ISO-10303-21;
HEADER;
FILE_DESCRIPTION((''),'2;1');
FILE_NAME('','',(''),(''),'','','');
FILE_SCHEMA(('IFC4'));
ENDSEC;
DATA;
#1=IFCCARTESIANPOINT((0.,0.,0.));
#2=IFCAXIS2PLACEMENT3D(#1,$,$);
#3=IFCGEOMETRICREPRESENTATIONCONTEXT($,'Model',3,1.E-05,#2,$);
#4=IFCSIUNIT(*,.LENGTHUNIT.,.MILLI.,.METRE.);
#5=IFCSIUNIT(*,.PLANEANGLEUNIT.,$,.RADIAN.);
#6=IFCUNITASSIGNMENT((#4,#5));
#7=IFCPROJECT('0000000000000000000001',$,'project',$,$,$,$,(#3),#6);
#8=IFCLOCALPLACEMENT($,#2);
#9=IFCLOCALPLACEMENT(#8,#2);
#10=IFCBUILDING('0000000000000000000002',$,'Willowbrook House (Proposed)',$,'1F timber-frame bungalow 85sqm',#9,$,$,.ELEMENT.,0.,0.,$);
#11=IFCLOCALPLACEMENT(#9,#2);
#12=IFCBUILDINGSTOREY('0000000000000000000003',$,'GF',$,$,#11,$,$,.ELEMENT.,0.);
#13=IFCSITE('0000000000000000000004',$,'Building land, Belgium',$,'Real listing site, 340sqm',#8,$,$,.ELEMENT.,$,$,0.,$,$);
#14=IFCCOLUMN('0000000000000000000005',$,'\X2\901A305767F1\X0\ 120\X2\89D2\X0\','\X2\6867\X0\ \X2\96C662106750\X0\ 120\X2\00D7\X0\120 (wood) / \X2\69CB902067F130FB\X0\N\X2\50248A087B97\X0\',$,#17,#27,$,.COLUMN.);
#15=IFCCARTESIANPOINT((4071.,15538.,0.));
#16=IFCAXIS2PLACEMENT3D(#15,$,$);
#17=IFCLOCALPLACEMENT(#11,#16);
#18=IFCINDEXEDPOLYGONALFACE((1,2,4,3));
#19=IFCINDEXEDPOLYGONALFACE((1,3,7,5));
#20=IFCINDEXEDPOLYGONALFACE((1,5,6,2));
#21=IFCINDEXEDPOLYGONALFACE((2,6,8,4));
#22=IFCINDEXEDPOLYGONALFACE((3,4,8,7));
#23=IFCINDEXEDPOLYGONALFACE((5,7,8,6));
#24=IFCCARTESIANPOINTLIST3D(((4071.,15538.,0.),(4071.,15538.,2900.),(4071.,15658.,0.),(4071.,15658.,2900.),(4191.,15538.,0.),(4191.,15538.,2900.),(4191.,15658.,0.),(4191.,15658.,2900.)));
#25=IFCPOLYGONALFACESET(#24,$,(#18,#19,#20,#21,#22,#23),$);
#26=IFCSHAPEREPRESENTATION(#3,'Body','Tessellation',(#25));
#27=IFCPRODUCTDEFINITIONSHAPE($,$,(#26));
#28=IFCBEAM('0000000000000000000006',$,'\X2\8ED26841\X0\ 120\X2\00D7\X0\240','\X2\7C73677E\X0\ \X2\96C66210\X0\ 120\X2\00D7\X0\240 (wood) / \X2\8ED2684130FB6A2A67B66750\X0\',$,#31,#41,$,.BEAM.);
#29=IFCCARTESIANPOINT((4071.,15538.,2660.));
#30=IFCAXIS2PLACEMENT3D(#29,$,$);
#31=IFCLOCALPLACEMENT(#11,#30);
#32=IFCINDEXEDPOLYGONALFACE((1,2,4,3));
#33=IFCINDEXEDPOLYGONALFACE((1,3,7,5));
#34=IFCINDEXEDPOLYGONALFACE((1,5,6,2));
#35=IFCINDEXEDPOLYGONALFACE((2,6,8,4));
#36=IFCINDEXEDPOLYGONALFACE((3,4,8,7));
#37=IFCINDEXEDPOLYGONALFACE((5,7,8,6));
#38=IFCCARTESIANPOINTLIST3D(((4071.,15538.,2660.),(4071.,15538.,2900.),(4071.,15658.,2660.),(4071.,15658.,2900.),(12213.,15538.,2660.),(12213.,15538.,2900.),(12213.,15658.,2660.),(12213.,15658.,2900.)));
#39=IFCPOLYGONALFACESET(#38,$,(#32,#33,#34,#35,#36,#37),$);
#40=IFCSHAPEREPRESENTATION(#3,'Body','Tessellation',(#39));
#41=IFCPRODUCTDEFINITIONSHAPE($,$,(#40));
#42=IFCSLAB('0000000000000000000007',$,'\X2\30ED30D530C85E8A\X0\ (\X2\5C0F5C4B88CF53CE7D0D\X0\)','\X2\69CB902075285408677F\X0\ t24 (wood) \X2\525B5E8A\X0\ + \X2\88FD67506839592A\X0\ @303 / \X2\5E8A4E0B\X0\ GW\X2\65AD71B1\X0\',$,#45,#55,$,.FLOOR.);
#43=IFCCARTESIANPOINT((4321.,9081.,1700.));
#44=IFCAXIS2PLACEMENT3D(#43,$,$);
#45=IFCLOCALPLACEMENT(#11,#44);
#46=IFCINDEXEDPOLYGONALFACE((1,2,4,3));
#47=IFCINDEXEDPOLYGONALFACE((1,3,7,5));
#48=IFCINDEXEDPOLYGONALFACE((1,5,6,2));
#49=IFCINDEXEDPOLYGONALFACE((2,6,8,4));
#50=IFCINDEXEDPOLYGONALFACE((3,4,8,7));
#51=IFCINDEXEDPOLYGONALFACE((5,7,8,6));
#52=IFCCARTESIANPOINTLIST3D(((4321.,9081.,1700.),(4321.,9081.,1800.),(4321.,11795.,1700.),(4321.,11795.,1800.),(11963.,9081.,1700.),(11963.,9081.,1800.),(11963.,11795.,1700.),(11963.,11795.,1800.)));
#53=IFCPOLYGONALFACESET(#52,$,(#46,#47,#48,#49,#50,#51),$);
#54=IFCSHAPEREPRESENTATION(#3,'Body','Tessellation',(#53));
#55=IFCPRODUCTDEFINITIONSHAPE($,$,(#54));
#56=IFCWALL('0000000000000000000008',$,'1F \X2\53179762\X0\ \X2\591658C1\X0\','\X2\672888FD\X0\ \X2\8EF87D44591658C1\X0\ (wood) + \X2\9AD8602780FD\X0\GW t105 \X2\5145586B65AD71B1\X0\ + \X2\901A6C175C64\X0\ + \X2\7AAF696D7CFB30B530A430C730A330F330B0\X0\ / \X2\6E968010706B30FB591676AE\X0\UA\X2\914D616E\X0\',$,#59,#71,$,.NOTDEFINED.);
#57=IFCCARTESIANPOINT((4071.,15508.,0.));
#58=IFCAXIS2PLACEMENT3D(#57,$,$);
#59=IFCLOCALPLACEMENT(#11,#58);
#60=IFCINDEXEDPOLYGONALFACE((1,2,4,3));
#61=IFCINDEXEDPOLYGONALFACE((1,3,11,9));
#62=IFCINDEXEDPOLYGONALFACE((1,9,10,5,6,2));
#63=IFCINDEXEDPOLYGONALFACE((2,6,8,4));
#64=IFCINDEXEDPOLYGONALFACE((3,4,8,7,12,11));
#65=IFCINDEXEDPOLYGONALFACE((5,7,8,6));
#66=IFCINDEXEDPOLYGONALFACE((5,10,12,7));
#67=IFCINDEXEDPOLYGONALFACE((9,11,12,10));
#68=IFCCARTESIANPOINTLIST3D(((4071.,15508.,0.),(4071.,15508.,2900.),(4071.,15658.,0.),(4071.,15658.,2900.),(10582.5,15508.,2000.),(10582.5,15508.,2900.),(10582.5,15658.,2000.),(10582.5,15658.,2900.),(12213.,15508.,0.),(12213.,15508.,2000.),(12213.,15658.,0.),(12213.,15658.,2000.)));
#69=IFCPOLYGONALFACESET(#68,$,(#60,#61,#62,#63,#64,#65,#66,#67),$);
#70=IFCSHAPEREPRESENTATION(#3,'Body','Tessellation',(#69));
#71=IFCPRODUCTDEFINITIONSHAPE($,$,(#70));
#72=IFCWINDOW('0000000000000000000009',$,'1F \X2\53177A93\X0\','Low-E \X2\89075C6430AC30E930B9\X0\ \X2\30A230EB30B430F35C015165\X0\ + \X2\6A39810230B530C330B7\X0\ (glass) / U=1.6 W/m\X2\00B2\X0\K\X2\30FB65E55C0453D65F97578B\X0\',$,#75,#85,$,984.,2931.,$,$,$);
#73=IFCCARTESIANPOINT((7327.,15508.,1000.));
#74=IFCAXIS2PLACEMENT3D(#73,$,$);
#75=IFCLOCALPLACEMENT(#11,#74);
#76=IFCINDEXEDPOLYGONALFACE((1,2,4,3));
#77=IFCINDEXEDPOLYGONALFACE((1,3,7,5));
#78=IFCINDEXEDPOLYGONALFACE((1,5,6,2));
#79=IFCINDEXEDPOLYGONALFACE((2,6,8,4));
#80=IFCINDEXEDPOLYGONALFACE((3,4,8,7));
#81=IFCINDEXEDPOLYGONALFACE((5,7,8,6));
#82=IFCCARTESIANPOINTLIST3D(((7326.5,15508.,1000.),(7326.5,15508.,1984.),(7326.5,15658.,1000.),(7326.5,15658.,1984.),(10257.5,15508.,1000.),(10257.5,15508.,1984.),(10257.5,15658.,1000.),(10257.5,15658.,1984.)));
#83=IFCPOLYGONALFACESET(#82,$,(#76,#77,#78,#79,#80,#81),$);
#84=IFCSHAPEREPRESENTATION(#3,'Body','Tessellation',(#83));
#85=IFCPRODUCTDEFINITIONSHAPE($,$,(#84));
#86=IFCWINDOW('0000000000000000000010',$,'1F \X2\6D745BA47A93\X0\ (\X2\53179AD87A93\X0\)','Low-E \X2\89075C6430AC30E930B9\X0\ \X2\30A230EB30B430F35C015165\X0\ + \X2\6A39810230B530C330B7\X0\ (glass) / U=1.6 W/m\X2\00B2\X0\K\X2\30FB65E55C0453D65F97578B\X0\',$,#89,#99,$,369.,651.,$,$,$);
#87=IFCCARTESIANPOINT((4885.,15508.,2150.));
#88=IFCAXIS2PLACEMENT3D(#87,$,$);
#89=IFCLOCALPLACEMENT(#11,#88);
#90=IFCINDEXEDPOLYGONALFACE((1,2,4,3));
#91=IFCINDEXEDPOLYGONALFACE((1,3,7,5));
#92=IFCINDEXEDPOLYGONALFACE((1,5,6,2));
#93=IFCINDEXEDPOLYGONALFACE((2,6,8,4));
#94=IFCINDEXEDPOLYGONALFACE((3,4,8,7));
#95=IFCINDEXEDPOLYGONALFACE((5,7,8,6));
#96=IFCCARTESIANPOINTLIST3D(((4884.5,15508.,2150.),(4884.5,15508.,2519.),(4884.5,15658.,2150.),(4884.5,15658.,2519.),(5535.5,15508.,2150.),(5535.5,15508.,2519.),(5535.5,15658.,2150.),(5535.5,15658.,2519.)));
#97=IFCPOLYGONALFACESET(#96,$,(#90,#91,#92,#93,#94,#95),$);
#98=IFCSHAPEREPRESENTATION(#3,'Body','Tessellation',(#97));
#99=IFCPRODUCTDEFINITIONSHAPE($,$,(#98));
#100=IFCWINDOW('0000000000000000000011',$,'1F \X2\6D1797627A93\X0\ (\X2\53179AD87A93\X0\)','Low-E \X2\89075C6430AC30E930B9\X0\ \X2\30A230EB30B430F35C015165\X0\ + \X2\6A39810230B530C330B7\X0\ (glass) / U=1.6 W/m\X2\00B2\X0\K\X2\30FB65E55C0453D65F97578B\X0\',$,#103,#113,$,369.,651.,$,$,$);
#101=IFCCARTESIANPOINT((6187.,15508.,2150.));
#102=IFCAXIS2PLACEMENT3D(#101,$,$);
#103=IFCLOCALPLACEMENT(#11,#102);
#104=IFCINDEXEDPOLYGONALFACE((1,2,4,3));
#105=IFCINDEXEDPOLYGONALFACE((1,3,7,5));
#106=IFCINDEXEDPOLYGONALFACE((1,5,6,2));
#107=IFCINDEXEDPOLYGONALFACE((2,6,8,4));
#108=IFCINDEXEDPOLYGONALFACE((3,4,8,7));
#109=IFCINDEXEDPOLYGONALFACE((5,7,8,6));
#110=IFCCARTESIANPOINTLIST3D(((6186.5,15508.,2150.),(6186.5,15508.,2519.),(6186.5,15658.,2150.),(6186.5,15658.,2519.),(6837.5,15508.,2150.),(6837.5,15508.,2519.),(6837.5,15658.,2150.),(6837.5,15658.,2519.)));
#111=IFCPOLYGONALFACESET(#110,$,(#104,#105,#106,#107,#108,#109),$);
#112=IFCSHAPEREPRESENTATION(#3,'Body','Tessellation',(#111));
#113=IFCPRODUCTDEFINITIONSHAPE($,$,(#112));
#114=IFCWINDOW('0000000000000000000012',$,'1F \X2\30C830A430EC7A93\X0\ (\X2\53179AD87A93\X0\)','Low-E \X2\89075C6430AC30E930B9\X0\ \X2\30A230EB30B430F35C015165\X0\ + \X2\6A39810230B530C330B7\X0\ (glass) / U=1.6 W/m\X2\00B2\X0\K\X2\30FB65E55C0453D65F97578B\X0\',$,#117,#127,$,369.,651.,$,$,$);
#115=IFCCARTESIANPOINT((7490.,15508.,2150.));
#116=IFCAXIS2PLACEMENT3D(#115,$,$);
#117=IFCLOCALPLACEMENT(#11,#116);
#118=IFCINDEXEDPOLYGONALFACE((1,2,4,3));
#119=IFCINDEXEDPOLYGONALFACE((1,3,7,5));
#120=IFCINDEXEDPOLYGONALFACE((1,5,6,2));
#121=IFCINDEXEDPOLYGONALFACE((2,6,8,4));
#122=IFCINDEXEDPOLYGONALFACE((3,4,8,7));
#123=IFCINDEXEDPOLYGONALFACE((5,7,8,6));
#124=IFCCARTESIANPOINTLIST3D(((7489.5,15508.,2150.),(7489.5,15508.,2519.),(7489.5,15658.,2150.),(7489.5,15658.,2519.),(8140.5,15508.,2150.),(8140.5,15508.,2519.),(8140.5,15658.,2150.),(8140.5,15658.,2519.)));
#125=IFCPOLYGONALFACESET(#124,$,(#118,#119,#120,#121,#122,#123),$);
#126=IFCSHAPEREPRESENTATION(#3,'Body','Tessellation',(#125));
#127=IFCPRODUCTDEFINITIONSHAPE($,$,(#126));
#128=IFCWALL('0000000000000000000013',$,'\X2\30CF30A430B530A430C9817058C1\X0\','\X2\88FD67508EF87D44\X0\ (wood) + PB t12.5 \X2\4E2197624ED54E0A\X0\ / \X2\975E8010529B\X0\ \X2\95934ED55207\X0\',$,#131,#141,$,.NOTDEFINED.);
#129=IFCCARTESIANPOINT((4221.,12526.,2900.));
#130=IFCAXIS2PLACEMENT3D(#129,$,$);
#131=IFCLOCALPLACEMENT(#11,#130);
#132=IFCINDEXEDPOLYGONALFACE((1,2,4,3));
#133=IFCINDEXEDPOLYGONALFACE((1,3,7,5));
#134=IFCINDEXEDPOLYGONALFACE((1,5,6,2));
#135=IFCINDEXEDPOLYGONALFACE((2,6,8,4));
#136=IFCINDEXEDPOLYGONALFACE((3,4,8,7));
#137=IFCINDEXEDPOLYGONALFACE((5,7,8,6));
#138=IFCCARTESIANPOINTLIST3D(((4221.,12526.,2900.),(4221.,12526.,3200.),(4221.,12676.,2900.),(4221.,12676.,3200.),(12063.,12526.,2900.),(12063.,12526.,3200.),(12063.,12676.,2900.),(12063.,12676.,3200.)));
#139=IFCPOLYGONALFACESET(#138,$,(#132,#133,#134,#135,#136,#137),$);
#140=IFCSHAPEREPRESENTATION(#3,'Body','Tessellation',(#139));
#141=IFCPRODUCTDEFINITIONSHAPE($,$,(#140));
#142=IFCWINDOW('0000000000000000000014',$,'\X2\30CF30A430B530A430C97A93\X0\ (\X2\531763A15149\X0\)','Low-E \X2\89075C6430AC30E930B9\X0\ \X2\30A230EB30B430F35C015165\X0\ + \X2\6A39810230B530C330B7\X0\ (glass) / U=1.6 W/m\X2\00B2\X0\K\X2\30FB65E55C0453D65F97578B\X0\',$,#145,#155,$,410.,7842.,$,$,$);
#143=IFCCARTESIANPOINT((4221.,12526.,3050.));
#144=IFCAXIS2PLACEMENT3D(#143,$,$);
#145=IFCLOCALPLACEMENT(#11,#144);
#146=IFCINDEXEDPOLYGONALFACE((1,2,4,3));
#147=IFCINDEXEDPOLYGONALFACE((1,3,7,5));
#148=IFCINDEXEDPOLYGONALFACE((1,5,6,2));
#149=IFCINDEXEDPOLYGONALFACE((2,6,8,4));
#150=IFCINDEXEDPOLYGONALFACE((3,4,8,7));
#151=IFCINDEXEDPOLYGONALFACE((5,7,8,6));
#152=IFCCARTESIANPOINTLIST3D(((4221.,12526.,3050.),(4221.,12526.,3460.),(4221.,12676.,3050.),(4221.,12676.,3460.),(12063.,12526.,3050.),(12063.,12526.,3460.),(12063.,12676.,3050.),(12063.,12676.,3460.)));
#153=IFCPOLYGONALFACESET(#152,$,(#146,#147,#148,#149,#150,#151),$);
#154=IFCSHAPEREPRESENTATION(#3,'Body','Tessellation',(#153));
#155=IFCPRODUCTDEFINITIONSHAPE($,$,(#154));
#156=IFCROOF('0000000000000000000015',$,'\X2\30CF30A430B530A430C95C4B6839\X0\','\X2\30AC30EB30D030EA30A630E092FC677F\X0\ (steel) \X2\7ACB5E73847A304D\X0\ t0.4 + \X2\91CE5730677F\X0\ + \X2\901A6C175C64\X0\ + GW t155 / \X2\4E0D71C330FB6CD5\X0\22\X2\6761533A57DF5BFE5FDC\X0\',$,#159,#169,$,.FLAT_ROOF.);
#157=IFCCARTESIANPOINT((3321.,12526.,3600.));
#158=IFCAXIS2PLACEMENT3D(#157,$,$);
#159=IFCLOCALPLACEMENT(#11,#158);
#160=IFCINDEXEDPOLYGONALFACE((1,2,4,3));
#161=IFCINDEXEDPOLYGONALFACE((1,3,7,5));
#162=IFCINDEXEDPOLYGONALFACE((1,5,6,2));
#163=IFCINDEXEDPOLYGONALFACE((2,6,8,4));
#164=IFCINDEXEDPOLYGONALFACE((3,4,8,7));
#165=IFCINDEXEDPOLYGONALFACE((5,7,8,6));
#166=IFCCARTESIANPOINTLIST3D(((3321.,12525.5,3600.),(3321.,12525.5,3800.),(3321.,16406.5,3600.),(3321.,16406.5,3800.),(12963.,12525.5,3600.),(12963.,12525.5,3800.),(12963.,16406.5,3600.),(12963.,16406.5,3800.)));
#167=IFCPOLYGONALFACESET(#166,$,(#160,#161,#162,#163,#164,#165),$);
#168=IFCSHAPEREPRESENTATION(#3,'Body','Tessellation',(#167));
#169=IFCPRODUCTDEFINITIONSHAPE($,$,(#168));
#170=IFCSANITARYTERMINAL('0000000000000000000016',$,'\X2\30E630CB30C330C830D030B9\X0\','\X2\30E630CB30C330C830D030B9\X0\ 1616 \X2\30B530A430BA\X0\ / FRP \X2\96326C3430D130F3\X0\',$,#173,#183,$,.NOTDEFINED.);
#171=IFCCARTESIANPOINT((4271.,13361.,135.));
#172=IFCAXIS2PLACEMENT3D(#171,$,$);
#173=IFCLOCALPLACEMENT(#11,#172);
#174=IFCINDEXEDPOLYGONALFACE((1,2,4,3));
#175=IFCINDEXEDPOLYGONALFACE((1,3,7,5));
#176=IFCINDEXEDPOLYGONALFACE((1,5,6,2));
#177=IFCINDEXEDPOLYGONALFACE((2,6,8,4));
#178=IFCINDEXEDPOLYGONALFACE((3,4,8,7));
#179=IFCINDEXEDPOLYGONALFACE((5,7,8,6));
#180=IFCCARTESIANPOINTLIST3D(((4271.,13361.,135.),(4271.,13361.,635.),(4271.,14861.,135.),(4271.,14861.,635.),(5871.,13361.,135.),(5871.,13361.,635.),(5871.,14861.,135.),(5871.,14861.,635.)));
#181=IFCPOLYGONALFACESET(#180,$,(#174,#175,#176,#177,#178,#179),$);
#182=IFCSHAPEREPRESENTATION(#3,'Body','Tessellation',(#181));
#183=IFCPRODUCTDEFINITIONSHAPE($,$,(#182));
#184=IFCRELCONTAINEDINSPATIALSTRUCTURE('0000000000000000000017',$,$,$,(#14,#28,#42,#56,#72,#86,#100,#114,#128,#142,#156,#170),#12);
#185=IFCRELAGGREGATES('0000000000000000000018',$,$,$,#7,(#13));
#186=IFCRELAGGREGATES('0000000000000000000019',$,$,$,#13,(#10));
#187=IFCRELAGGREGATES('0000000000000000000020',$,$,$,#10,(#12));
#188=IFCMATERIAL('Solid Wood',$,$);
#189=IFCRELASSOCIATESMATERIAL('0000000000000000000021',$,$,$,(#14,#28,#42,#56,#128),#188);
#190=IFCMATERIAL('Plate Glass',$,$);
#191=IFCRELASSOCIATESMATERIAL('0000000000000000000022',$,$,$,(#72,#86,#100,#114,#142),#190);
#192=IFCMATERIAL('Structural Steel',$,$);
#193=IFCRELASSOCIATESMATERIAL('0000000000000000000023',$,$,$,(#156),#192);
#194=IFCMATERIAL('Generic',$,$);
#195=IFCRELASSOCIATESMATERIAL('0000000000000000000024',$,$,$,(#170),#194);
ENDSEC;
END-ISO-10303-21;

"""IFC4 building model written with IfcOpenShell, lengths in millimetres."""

from ifc_helpers import new_model, si_unit, frame, frame_2d, origin, place, context, project, spatial, rectangle, extrude, material, element, fill, save


model = new_model("IFC4")

# Units and contexts
model_context = context("Model", 3, precision=1e-05, world=origin())
ifc_project = project(units=[si_unit("LENGTHUNIT", "METRE", prefix="MILLI"), si_unit("PLANEANGLEUNIT", "RADIAN")], contexts=[model_context])

# Site, building, storey
site_placement = place(None, origin())
site = spatial("IfcSite", under=ifc_project, at=site_placement, Name="Building land, Belgium", ObjectType="Real listing site, 340sqm", CompositionType="ELEMENT", RefElevation=0.0)
building_placement = place(site_placement, origin())
building = spatial("IfcBuilding", under=site, at=building_placement, Name="Willowbrook House (Proposed)", ObjectType="1F timber-frame bungalow 85sqm", CompositionType="ELEMENT", ElevationOfRefHeight=0.0, ElevationOfTerrain=0.0)
storey_placement = place(building_placement, origin())
storey = spatial("IfcBuildingStorey", under=building, at=storey_placement, Name="GF", CompositionType="ELEMENT", Elevation=0.0)

# Column
ifc_material_1 = material(Name="Solid Wood")
column_1_placement = place(storey_placement, frame((4071.0, 15538.0, 0.0)))
element("IfcColumn", 1, at=column_1_placement, inside=storey, material=ifc_material_1, Name="通し柱 120角", Description="桧 集成材 120×120 (wood) / 構造柱・N値計算", PredefinedType="COLUMN", context=model_context, shape_type="SweptSolid", body=[
    extrude(rectangle(XDim=120.0, YDim=120.0, at=frame_2d((60.0, 60.0))), frame((4071.0, 15538.0, 0.0)), (0.0, 0.0, 1.0), 2900.0),
])

# Beam
beam_1_placement = place(storey_placement, frame((4071.0, 15538.0, 2660.0)))
element("IfcBeam", 2, at=beam_1_placement, inside=storey, material=ifc_material_1, Name="軒桁 120×240", Description="米松 集成 120×240 (wood) / 軒桁・横架材", PredefinedType="BEAM", context=model_context, shape_type="SweptSolid", body=[
    extrude(rectangle(XDim=8142.0, YDim=120.0, at=frame_2d((4071.0, 60.0))), frame((4071.0, 15538.0, 2660.0)), (0.0, 0.0, 1.0), 240.0),
])

# Slab
slab_placement = place(storey_placement, frame((4321.0, 9081.0, 1700.0)))
element("IfcSlab", 3, at=slab_placement, inside=storey, material=ifc_material_1, Name="ロフト床 (小屋裏収納)", Description="構造用合板 t24 (wood) 剛床 + 製材根太 @303 / 床下 GW断熱", PredefinedType="FLOOR", context=model_context, shape_type="SweptSolid", body=[
    extrude(rectangle(XDim=7642.0, YDim=2714.0, at=frame_2d((3821.0, 1357.0))), frame((4321.0, 9081.0, 1700.0)), (0.0, 0.0, 1.0), 100.0),
])

# Wall, openings, windows
wall_1_placement = place(storey_placement, frame((4071.0, 15508.0, 0.0)))
wall_1 = element("IfcWall", 4, at=wall_1_placement, inside=storey, material=ifc_material_1, Name="1F 北面 外壁", Description="木製 軸組外壁 (wood) + 高性能GW t105 充填断熱 + 通気層 + 窯業系サイディング / 準耐火・外皮UA配慮", PredefinedType="NOTDEFINED", context=model_context, shape_type="SweptSolid", body=[
    extrude(rectangle(XDim=8142.0, YDim=150.0, at=frame_2d((4071.0, 75.0))), frame((4071.0, 15508.0, 0.0)), (0.0, 0.0, 1.0), 2900.0),
])
opening_1_placement = place(storey_placement, frame((7327.0, 15508.0, 1000.0)))
opening_1 = element("IfcOpeningElement", 5, at=opening_1_placement, cuts=wall_1, PredefinedType="NOTDEFINED", context=model_context, shape_type="SweptSolid", body=[
    extrude(rectangle(XDim=2931.0, YDim=150.0, at=frame_2d((1465.0, 75.0))), frame((7327.0, 15508.0, 1000.0)), (0.0, 0.0, 1.0), 984.0),
])
opening_2_placement = place(storey_placement, frame((4885.0, 15508.0, 2150.0)))
opening_2 = element("IfcOpeningElement", 6, at=opening_2_placement, cuts=wall_1, PredefinedType="NOTDEFINED", context=model_context, shape_type="SweptSolid", body=[
    extrude(rectangle(XDim=651.0, YDim=150.0, at=frame_2d((325.0, 75.0))), frame((4885.0, 15508.0, 2150.0)), (0.0, 0.0, 1.0), 369.0),
])
opening_3_placement = place(storey_placement, frame((6187.0, 15508.0, 2150.0)))
opening_3 = element("IfcOpeningElement", 7, at=opening_3_placement, cuts=wall_1, PredefinedType="NOTDEFINED", context=model_context, shape_type="SweptSolid", body=[
    extrude(rectangle(XDim=651.0, YDim=150.0, at=frame_2d((325.0, 75.0))), frame((6187.0, 15508.0, 2150.0)), (0.0, 0.0, 1.0), 369.0),
])
opening_4_placement = place(storey_placement, frame((7490.0, 15508.0, 2150.0)))
opening_4 = element("IfcOpeningElement", 8, at=opening_4_placement, cuts=wall_1, PredefinedType="NOTDEFINED", context=model_context, shape_type="SweptSolid", body=[
    extrude(rectangle(XDim=651.0, YDim=150.0, at=frame_2d((325.0, 75.0))), frame((7490.0, 15508.0, 2150.0)), (0.0, 0.0, 1.0), 369.0),
])
ifc_material_2 = material(Name="Plate Glass")
window_1_placement = place(storey_placement, frame((7327.0, 15508.0, 1000.0)))
window_1 = element("IfcWindow", 9, at=window_1_placement, inside=storey, material=ifc_material_2, Name="1F 北窓", Description="Low-E 複層ガラス アルゴン封入 + 樹脂サッシ (glass) / U=1.6 W/m²K・日射取得型", OverallHeight=984.0, OverallWidth=2931.0, context=model_context, shape_type="SweptSolid", body=[
    extrude(rectangle(XDim=2931.0, YDim=150.0, at=frame_2d((1465.0, 75.0))), frame((7327.0, 15508.0, 1000.0)), (0.0, 0.0, 1.0), 984.0),
])
fill(opening_1, window_1)
window_2_placement = place(storey_placement, frame((4885.0, 15508.0, 2150.0)))
window_2 = element("IfcWindow", 10, at=window_2_placement, inside=storey, material=ifc_material_2, Name="1F 浴室窓 (北高窓)", Description="Low-E 複層ガラス アルゴン封入 + 樹脂サッシ (glass) / U=1.6 W/m²K・日射取得型", OverallHeight=369.0, OverallWidth=651.0, context=model_context, shape_type="SweptSolid", body=[
    extrude(rectangle(XDim=651.0, YDim=150.0, at=frame_2d((325.0, 75.0))), frame((4885.0, 15508.0, 2150.0)), (0.0, 0.0, 1.0), 369.0),
])
fill(opening_2, window_2)
window_3_placement = place(storey_placement, frame((6187.0, 15508.0, 2150.0)))
window_3 = element("IfcWindow", 11, at=window_3_placement, inside=storey, material=ifc_material_2, Name="1F 洗面窓 (北高窓)", Description="Low-E 複層ガラス アルゴン封入 + 樹脂サッシ (glass) / U=1.6 W/m²K・日射取得型", OverallHeight=369.0, OverallWidth=651.0, context=model_context, shape_type="SweptSolid", body=[
    extrude(rectangle(XDim=651.0, YDim=150.0, at=frame_2d((325.0, 75.0))), frame((6187.0, 15508.0, 2150.0)), (0.0, 0.0, 1.0), 369.0),
])
fill(opening_3, window_3)
window_4_placement = place(storey_placement, frame((7490.0, 15508.0, 2150.0)))
window_4 = element("IfcWindow", 12, at=window_4_placement, inside=storey, material=ifc_material_2, Name="1F トイレ窓 (北高窓)", Description="Low-E 複層ガラス アルゴン封入 + 樹脂サッシ (glass) / U=1.6 W/m²K・日射取得型", OverallHeight=369.0, OverallWidth=651.0, context=model_context, shape_type="SweptSolid", body=[
    extrude(rectangle(XDim=651.0, YDim=150.0, at=frame_2d((325.0, 75.0))), frame((7490.0, 15508.0, 2150.0)), (0.0, 0.0, 1.0), 369.0),
])
fill(opening_4, window_4)

# Wall, opening, window
wall_2_placement = place(storey_placement, frame((4221.0, 12526.0, 2900.0)))
wall_2 = element("IfcWall", 13, at=wall_2_placement, inside=storey, material=ifc_material_1, Name="ハイサイド腰壁", Description="製材軸組 (wood) + PB t12.5 両面仕上 / 非耐力 間仕切", PredefinedType="NOTDEFINED", context=model_context, shape_type="SweptSolid", body=[
    extrude(rectangle(XDim=7842.0, YDim=150.0, at=frame_2d((3921.0, 75.0))), frame((4221.0, 12526.0, 2900.0)), (0.0, 0.0, 1.0), 700.0),
])
opening_5_placement = place(storey_placement, frame((4221.0, 12526.0, 3050.0)))
opening_5 = element("IfcOpeningElement", 14, at=opening_5_placement, cuts=wall_2, PredefinedType="NOTDEFINED", context=model_context, shape_type="SweptSolid", body=[
    extrude(rectangle(XDim=7842.0, YDim=150.0, at=frame_2d((3921.0, 75.0))), frame((4221.0, 12526.0, 3050.0)), (0.0, 0.0, 1.0), 410.0),
])
window_5_placement = place(storey_placement, frame((4221.0, 12526.0, 3050.0)))
window_5 = element("IfcWindow", 15, at=window_5_placement, inside=storey, material=ifc_material_2, Name="ハイサイド窓 (北採光)", Description="Low-E 複層ガラス アルゴン封入 + 樹脂サッシ (glass) / U=1.6 W/m²K・日射取得型", OverallHeight=410.0, OverallWidth=7842.0, context=model_context, shape_type="SweptSolid", body=[
    extrude(rectangle(XDim=7842.0, YDim=150.0, at=frame_2d((3921.0, 75.0))), frame((4221.0, 12526.0, 3050.0)), (0.0, 0.0, 1.0), 410.0),
])
fill(opening_5, window_5)

# Roof
ifc_material_3 = material(Name="Structural Steel")
roof_placement = place(storey_placement, frame((3321.0, 12526.0, 3600.0)))
element("IfcRoof", 16, at=roof_placement, inside=storey, material=ifc_material_3, Name="ハイサイド屋根", Description="ガルバリウム鋼板 (steel) 立平葺き t0.4 + 野地板 + 通気層 + GW t155 / 不燃・法22条区域対応", PredefinedType="FLAT_ROOF", context=model_context, shape_type="SweptSolid", body=[
    extrude(rectangle(XDim=9642.0, YDim=3881.0, at=frame_2d((4821.0, 1940.0))), frame((3321.0, 12526.0, 3600.0)), (0.0, 0.0, 1.0), 200.0),
])

# Sanitary terminal
ifc_material_4 = material(Name="Generic")
sanitary_terminal_placement = place(storey_placement, frame((4271.0, 13361.0, 135.0)))
element("IfcSanitaryTerminal", 17, at=sanitary_terminal_placement, inside=storey, material=ifc_material_4, Name="ユニットバス", Description="ユニットバス 1616 サイズ / FRP 防水パン", PredefinedType="NOTDEFINED", context=model_context, shape_type="SweptSolid", body=[
    extrude(rectangle(XDim=1600.0, YDim=1500.0, at=frame_2d((800.0, 750.0))), frame((4271.0, 13361.0, 135.0)), (0.0, 0.0, 1.0), 500.0),
])

save(model, "model.ifc")
